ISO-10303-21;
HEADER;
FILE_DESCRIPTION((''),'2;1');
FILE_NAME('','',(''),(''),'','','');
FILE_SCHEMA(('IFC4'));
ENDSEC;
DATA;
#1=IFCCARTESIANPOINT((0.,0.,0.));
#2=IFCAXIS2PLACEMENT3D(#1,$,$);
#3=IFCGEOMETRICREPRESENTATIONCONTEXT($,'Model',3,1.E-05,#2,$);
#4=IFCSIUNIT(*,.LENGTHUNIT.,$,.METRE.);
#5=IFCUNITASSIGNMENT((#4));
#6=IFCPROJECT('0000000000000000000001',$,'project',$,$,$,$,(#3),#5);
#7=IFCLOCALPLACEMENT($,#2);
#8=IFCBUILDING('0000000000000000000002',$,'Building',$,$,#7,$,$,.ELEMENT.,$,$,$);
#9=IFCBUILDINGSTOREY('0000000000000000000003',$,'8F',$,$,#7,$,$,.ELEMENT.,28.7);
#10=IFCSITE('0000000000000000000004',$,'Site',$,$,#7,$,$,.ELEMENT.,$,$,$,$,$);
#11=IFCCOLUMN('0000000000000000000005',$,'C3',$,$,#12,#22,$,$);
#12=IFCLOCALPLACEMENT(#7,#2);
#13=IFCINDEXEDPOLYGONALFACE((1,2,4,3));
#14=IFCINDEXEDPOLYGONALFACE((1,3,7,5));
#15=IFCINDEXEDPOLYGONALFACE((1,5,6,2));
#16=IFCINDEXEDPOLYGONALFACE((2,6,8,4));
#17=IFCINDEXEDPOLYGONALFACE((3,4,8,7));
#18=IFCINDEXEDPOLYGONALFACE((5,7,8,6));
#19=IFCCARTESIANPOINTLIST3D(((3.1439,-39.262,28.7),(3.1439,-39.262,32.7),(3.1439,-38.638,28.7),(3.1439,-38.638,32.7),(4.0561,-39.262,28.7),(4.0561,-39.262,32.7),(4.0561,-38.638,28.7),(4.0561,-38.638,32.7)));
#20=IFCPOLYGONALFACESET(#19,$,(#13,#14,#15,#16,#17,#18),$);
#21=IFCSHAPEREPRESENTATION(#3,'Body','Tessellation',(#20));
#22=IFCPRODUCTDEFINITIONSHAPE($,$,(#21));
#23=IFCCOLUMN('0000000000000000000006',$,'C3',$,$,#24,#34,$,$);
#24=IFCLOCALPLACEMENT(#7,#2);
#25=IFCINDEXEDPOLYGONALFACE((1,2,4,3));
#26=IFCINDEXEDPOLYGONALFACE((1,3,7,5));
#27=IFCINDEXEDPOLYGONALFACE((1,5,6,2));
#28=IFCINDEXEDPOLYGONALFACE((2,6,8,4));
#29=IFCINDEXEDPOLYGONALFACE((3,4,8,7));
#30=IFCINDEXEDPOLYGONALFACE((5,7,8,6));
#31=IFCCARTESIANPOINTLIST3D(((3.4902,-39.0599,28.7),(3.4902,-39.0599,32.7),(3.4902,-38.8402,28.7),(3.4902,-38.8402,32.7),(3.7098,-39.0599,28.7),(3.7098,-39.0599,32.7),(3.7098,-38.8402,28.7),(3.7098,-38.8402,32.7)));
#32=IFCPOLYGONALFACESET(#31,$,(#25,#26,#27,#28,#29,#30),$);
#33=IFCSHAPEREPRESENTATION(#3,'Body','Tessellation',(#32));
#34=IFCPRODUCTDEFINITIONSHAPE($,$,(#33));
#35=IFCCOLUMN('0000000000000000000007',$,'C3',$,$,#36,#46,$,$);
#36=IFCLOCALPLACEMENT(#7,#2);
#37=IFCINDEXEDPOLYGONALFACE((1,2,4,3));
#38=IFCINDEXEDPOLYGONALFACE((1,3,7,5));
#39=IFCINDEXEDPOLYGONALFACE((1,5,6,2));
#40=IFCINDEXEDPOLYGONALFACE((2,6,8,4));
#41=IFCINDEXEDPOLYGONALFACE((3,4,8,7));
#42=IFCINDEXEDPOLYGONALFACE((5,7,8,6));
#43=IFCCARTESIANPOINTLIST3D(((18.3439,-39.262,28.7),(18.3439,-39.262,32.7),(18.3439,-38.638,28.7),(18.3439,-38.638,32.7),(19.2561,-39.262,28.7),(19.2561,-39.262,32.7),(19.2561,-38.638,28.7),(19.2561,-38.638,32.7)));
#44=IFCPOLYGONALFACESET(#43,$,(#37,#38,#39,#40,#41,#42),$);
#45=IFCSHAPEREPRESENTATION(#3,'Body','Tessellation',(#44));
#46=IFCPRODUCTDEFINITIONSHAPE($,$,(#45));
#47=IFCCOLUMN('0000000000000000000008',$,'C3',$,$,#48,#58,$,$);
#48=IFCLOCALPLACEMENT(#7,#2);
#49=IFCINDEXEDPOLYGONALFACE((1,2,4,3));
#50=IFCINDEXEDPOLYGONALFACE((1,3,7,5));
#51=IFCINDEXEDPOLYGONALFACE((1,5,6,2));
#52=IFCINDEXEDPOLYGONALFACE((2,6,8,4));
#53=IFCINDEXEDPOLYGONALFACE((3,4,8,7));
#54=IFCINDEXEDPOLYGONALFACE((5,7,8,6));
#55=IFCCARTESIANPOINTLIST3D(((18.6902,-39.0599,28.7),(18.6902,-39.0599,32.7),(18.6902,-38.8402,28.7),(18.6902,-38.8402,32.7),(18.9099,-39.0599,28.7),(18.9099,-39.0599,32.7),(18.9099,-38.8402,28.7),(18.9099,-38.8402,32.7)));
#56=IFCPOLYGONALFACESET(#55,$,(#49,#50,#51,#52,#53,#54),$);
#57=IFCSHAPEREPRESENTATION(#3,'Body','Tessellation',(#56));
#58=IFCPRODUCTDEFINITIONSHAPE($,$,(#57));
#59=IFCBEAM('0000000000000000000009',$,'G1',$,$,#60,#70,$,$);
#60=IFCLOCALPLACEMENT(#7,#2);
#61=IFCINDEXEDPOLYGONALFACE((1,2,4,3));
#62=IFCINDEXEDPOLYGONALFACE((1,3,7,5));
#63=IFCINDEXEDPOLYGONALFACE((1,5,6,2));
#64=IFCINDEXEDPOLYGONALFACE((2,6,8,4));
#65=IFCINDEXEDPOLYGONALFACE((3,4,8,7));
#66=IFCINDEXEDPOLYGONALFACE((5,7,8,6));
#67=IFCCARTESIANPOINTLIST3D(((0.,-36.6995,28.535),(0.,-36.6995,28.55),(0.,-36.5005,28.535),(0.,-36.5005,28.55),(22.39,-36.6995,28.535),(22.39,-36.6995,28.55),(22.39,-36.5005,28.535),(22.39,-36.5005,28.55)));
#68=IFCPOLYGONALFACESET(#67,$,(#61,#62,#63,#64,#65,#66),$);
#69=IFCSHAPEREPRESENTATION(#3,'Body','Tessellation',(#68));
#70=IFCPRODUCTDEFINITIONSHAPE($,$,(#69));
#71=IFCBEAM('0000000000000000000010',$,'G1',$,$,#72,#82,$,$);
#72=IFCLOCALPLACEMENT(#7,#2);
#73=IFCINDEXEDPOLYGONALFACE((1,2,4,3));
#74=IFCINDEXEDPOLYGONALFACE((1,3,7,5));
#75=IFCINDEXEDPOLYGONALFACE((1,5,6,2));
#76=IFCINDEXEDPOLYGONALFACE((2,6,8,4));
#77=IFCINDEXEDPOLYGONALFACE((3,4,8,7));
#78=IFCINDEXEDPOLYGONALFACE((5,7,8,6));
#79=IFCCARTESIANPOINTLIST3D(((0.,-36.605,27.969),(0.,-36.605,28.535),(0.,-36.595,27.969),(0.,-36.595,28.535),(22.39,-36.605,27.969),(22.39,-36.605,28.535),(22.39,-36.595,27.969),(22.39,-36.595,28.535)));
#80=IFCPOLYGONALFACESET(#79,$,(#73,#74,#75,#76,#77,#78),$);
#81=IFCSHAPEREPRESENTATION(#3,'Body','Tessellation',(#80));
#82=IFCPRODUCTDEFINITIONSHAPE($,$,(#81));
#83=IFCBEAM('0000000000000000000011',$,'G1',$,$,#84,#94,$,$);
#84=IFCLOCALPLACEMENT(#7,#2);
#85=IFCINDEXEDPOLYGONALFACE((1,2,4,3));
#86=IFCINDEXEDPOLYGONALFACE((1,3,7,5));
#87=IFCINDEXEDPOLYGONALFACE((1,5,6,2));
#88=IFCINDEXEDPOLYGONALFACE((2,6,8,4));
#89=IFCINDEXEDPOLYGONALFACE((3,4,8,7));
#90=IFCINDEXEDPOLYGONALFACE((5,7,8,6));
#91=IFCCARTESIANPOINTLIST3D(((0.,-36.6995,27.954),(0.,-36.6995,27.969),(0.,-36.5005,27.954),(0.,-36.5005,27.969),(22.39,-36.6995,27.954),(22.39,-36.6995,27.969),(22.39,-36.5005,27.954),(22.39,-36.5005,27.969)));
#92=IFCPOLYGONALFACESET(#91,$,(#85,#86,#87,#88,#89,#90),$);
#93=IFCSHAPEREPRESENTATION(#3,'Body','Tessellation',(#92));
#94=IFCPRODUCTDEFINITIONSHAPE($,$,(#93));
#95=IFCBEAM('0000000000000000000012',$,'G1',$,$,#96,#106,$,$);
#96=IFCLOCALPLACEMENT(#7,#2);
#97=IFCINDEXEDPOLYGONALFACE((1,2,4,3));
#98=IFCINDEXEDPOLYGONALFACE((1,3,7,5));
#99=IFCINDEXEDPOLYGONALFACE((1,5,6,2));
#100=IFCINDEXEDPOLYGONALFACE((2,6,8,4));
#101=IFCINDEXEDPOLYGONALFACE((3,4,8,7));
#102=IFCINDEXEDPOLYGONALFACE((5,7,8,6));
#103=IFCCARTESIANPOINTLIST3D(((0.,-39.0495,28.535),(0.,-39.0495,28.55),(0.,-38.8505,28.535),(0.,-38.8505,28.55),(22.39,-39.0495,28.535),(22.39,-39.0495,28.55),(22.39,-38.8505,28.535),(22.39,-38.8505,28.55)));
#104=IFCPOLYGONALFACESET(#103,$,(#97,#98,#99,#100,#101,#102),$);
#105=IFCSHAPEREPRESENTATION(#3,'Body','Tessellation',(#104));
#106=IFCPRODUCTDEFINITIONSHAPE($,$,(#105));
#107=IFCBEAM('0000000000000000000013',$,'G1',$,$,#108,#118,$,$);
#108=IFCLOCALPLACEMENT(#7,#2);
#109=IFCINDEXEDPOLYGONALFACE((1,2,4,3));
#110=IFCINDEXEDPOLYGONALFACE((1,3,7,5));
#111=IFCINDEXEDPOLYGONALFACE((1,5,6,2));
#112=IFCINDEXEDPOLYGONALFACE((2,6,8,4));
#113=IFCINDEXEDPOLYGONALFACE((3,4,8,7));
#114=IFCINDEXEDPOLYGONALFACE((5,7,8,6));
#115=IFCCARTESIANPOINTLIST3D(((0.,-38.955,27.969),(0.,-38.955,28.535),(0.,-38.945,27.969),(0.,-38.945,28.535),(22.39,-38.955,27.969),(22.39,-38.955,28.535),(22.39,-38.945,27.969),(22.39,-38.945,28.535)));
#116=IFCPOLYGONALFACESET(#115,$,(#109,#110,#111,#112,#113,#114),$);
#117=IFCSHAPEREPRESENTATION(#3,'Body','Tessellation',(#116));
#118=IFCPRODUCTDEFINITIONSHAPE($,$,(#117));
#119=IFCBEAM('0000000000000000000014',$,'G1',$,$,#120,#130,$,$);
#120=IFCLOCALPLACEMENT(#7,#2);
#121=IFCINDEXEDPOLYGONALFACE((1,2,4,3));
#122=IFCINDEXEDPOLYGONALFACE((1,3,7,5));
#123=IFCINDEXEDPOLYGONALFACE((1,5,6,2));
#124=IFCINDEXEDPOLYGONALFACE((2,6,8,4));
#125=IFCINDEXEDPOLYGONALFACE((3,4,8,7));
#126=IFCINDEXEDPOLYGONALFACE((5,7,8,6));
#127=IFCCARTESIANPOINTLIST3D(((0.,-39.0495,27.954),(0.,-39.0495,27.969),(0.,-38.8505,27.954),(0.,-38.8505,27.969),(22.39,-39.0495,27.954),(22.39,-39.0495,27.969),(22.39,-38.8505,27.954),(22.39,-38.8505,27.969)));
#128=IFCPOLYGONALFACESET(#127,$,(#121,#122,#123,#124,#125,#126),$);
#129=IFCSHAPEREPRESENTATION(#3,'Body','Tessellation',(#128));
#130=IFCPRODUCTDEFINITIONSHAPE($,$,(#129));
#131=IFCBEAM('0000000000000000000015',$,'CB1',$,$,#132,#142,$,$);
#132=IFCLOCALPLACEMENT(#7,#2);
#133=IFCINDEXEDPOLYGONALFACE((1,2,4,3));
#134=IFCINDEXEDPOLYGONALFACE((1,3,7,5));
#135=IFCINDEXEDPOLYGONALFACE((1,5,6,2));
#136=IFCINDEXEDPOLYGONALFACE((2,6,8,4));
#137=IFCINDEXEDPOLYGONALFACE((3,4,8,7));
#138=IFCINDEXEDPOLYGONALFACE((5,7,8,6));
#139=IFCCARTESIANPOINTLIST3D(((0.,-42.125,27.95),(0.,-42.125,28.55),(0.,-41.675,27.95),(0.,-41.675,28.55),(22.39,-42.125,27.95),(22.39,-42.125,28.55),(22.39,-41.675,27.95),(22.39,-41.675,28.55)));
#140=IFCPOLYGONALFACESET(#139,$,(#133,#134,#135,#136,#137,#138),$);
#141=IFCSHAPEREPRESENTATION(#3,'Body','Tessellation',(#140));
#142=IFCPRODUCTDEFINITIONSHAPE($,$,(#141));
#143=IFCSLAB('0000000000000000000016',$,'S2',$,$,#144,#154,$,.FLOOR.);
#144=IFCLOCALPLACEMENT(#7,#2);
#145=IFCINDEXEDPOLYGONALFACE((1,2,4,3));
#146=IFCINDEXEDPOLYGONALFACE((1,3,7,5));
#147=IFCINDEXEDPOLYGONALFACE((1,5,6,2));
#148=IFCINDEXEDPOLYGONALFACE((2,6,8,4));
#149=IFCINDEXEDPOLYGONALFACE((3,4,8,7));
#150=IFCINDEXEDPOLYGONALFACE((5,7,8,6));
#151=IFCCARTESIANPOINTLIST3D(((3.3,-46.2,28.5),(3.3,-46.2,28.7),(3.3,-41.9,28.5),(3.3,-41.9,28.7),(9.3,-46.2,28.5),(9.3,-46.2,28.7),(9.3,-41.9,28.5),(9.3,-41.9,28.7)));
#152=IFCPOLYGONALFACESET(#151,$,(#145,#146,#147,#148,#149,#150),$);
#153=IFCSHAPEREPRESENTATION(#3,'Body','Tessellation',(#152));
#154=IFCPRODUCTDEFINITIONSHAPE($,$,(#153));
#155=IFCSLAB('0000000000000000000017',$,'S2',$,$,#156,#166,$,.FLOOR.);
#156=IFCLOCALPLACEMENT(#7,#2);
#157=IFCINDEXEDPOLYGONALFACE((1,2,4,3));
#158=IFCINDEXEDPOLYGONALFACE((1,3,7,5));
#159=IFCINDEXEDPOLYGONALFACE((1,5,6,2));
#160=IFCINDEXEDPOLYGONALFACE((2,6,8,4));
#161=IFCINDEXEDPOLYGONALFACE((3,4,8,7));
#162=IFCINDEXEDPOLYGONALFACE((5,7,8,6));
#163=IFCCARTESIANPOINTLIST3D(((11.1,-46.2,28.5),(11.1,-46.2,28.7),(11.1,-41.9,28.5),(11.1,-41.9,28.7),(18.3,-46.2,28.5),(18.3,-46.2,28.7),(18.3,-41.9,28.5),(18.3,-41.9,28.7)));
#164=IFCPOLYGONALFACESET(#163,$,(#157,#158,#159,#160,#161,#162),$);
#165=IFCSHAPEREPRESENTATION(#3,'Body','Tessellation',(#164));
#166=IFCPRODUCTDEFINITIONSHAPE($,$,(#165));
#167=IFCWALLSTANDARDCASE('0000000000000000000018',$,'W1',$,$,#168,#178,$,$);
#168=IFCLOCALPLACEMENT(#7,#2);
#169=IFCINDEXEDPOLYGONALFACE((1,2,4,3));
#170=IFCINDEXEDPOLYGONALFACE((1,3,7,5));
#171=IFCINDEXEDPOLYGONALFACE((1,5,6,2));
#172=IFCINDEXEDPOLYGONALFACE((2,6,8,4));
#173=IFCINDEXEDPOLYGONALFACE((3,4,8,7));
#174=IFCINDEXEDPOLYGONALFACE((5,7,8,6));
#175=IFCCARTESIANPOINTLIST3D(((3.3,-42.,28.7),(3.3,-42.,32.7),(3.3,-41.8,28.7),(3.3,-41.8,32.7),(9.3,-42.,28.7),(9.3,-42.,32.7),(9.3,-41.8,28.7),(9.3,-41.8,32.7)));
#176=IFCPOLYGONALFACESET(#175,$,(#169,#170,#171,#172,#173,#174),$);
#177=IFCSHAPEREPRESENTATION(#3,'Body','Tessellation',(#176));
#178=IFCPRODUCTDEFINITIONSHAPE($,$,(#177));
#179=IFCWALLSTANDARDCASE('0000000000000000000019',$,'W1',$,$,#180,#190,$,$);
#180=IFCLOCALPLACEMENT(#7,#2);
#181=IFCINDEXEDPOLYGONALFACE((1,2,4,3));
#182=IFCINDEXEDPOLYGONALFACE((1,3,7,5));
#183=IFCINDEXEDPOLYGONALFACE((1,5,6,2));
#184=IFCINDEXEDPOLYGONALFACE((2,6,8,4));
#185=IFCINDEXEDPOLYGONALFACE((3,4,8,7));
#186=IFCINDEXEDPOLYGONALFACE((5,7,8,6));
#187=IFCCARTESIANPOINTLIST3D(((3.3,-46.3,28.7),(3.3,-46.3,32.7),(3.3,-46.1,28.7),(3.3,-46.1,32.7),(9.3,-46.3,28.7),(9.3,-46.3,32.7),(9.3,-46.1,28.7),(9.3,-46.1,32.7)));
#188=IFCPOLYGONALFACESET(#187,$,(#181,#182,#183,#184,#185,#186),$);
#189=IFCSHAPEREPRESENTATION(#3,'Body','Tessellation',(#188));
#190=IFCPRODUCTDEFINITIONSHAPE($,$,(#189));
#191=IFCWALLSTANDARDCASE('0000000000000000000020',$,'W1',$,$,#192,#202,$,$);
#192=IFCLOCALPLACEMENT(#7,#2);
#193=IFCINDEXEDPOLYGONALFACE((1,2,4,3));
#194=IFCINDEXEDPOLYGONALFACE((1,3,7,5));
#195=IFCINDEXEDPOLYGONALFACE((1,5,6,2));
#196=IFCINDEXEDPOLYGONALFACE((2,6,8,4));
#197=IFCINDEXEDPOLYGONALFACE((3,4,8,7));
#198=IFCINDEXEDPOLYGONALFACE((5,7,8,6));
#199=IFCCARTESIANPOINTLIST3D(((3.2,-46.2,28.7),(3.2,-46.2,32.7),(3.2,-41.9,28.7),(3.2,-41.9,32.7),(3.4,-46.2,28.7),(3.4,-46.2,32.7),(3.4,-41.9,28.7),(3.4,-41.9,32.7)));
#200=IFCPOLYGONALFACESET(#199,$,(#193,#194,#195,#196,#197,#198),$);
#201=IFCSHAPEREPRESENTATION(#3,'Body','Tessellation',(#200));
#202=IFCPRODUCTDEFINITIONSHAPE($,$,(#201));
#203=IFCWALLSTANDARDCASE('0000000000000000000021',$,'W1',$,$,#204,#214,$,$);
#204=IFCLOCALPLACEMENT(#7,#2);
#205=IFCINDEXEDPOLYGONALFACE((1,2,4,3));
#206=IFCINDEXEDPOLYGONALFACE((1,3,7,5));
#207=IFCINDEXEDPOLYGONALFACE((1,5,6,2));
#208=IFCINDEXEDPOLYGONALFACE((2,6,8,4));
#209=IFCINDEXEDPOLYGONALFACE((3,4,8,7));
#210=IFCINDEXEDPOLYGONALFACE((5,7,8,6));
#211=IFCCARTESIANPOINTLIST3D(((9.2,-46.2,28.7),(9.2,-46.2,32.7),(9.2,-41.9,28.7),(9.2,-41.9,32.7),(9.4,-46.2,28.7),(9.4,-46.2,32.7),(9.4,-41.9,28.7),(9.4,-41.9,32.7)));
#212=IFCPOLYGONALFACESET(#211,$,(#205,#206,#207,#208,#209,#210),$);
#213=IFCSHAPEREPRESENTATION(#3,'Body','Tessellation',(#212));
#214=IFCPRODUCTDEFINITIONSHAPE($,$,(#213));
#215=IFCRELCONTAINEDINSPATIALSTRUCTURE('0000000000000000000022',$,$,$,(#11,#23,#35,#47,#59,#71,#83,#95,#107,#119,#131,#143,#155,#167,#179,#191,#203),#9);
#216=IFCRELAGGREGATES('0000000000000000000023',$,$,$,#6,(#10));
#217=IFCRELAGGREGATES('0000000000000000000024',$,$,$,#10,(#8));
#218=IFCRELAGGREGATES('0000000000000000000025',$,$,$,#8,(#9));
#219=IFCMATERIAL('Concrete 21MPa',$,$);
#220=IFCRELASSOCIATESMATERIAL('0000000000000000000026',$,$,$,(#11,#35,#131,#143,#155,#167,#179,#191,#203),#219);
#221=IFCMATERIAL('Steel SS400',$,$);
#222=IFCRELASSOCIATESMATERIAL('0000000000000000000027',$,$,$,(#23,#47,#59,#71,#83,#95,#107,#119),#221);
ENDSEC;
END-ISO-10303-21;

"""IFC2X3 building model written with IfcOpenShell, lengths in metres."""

from ifc_helpers import new_model, si_unit, frame, origin, origin_2d, place, context, project, spatial, rectangle, extrude, material, element, save


model = new_model("IFC2X3")

# Units and contexts
model_context = context("Model", 3, precision=1e-05, world=origin())
ifc_project = project(units=[si_unit("LENGTHUNIT", "METRE")], contexts=[model_context])

# Site, building, storey
placement = place(None, origin())
site = spatial("IfcSite", under=ifc_project, at=placement, Name="Site", CompositionType="ELEMENT")
building = spatial("IfcBuilding", under=site, at=placement, Name="Building", CompositionType="ELEMENT")
storey = spatial("IfcBuildingStorey", under=building, at=placement, Name="8F", CompositionType="ELEMENT", Elevation=28.7)

# Columns
ifc_material_1 = material(Name="Concrete 21MPa")
column_1_placement = place(None, frame((3.6, -38.95, 28.7)))
element("IfcColumn", 1, at=column_1_placement, inside=storey, material=ifc_material_1, Name="C3", context=model_context, shape_type="SweptSolid", body=[
    extrude(rectangle(XDim=0.9121, YDim=0.6241, at=origin_2d()), origin(), (0.0, 0.0, 1.0), 4.0),
])
ifc_material_2 = material(Name="Steel SS400")
column_2_placement = place(None, frame((3.6, -38.95, 28.7)))
element("IfcColumn", 2, at=column_2_placement, inside=storey, material=ifc_material_2, Name="C3", context=model_context, shape_type="SweptSolid", body=[
    extrude(rectangle(XDim=0.2197, YDim=0.2197, at=origin_2d()), origin(), (0.0, 0.0, 1.0), 4.0),
])
column_3_placement = place(None, frame((18.8, -38.95, 28.7)))
element("IfcColumn", 3, at=column_3_placement, inside=storey, material=ifc_material_1, Name="C3", context=model_context, shape_type="SweptSolid", body=[
    extrude(rectangle(XDim=0.9121, YDim=0.6241, at=origin_2d()), origin(), (0.0, 0.0, 1.0), 4.0),
])
column_4_placement = place(None, frame((18.8, -38.95, 28.7)))
element("IfcColumn", 4, at=column_4_placement, inside=storey, material=ifc_material_2, Name="C3", context=model_context, shape_type="SweptSolid", body=[
    extrude(rectangle(XDim=0.2197, YDim=0.2197, at=origin_2d()), origin(), (0.0, 0.0, 1.0), 4.0),
])

# Beams
beam_1_placement = place(None, frame((11.195, -36.6, 28.535)))
element("IfcBeam", 5, at=beam_1_placement, inside=storey, material=ifc_material_2, Name="G1", context=model_context, shape_type="SweptSolid", body=[
    extrude(rectangle(XDim=22.39, YDim=0.199, at=origin_2d()), origin(), (0.0, 0.0, 1.0), 0.015),
])
beam_2_placement = place(None, frame((11.195, -36.6, 27.969)))
element("IfcBeam", 6, at=beam_2_placement, inside=storey, material=ifc_material_2, Name="G1", context=model_context, shape_type="SweptSolid", body=[
    extrude(rectangle(XDim=22.39, YDim=0.01, at=origin_2d()), origin(), (0.0, 0.0, 1.0), 0.566),
])
for number, where, name in (
    (7, (11.195, -36.6, 27.954), "G1"),
    (8, (11.195, -38.95, 28.535), "G1"),
):
    element("IfcBeam", number, at=place(None, frame(where)), inside=storey, material=ifc_material_2, Name=name, context=model_context, shape_type="SweptSolid", body=[
        extrude(rectangle(XDim=22.39, YDim=0.199, at=origin_2d()), origin(), (0.0, 0.0, 1.0), 0.015),
    ])
beam_3_placement = place(None, frame((11.195, -38.95, 27.969)))
element("IfcBeam", 9, at=beam_3_placement, inside=storey, material=ifc_material_2, Name="G1", context=model_context, shape_type="SweptSolid", body=[
    extrude(rectangle(XDim=22.39, YDim=0.01, at=origin_2d()), origin(), (0.0, 0.0, 1.0), 0.566),
])
beam_4_placement = place(None, frame((11.195, -38.95, 27.954)))
element("IfcBeam", 10, at=beam_4_placement, inside=storey, material=ifc_material_2, Name="G1", context=model_context, shape_type="SweptSolid", body=[
    extrude(rectangle(XDim=22.39, YDim=0.199, at=origin_2d()), origin(), (0.0, 0.0, 1.0), 0.015),
])
beam_5_placement = place(None, frame((11.195, -41.9, 27.95)))
element("IfcBeam", 11, at=beam_5_placement, inside=storey, material=ifc_material_1, Name="CB1", context=model_context, shape_type="SweptSolid", body=[
    extrude(rectangle(XDim=22.39, YDim=0.45, at=origin_2d()), origin(), (0.0, 0.0, 1.0), 0.6),
])

# Slabs
slab_1_placement = place(None, frame((6.3, -44.05, 28.5)))
element("IfcSlab", 12, at=slab_1_placement, inside=storey, material=ifc_material_1, Name="S2", PredefinedType="FLOOR", context=model_context, shape_type="SweptSolid", body=[
    extrude(rectangle(XDim=6.0, YDim=4.3, at=origin_2d()), origin(), (0.0, 0.0, 1.0), 0.2),
])
slab_2_placement = place(None, frame((14.7, -44.05, 28.5)))
element("IfcSlab", 13, at=slab_2_placement, inside=storey, material=ifc_material_1, Name="S2", PredefinedType="FLOOR", context=model_context, shape_type="SweptSolid", body=[
    extrude(rectangle(XDim=7.2, YDim=4.3, at=origin_2d()), origin(), (0.0, 0.0, 1.0), 0.2),
])

# Walls
for number, where, name in (
    (14, (6.3, -41.9, 28.7), "W1"),
    (15, (6.3, -46.2, 28.7), "W1"),
):
    element("IfcWallStandardCase", number, at=place(None, frame(where)), inside=storey, material=ifc_material_1, Name=name, context=model_context, shape_type="SweptSolid", body=[
        extrude(rectangle(XDim=6.0, YDim=0.2, at=origin_2d()), origin(), (0.0, 0.0, 1.0), 4.0),
    ])
for number, where, name in (
    (16, (3.3, -44.05, 28.7), "W1"),
    (17, (9.3, -44.05, 28.7), "W1"),
):
    element("IfcWallStandardCase", number, at=place(None, frame(where)), inside=storey, material=ifc_material_1, Name=name, context=model_context, shape_type="SweptSolid", body=[
        extrude(rectangle(XDim=0.2, YDim=4.3, at=origin_2d()), origin(), (0.0, 0.0, 1.0), 4.0),
    ])

save(model, "model.ifc")
